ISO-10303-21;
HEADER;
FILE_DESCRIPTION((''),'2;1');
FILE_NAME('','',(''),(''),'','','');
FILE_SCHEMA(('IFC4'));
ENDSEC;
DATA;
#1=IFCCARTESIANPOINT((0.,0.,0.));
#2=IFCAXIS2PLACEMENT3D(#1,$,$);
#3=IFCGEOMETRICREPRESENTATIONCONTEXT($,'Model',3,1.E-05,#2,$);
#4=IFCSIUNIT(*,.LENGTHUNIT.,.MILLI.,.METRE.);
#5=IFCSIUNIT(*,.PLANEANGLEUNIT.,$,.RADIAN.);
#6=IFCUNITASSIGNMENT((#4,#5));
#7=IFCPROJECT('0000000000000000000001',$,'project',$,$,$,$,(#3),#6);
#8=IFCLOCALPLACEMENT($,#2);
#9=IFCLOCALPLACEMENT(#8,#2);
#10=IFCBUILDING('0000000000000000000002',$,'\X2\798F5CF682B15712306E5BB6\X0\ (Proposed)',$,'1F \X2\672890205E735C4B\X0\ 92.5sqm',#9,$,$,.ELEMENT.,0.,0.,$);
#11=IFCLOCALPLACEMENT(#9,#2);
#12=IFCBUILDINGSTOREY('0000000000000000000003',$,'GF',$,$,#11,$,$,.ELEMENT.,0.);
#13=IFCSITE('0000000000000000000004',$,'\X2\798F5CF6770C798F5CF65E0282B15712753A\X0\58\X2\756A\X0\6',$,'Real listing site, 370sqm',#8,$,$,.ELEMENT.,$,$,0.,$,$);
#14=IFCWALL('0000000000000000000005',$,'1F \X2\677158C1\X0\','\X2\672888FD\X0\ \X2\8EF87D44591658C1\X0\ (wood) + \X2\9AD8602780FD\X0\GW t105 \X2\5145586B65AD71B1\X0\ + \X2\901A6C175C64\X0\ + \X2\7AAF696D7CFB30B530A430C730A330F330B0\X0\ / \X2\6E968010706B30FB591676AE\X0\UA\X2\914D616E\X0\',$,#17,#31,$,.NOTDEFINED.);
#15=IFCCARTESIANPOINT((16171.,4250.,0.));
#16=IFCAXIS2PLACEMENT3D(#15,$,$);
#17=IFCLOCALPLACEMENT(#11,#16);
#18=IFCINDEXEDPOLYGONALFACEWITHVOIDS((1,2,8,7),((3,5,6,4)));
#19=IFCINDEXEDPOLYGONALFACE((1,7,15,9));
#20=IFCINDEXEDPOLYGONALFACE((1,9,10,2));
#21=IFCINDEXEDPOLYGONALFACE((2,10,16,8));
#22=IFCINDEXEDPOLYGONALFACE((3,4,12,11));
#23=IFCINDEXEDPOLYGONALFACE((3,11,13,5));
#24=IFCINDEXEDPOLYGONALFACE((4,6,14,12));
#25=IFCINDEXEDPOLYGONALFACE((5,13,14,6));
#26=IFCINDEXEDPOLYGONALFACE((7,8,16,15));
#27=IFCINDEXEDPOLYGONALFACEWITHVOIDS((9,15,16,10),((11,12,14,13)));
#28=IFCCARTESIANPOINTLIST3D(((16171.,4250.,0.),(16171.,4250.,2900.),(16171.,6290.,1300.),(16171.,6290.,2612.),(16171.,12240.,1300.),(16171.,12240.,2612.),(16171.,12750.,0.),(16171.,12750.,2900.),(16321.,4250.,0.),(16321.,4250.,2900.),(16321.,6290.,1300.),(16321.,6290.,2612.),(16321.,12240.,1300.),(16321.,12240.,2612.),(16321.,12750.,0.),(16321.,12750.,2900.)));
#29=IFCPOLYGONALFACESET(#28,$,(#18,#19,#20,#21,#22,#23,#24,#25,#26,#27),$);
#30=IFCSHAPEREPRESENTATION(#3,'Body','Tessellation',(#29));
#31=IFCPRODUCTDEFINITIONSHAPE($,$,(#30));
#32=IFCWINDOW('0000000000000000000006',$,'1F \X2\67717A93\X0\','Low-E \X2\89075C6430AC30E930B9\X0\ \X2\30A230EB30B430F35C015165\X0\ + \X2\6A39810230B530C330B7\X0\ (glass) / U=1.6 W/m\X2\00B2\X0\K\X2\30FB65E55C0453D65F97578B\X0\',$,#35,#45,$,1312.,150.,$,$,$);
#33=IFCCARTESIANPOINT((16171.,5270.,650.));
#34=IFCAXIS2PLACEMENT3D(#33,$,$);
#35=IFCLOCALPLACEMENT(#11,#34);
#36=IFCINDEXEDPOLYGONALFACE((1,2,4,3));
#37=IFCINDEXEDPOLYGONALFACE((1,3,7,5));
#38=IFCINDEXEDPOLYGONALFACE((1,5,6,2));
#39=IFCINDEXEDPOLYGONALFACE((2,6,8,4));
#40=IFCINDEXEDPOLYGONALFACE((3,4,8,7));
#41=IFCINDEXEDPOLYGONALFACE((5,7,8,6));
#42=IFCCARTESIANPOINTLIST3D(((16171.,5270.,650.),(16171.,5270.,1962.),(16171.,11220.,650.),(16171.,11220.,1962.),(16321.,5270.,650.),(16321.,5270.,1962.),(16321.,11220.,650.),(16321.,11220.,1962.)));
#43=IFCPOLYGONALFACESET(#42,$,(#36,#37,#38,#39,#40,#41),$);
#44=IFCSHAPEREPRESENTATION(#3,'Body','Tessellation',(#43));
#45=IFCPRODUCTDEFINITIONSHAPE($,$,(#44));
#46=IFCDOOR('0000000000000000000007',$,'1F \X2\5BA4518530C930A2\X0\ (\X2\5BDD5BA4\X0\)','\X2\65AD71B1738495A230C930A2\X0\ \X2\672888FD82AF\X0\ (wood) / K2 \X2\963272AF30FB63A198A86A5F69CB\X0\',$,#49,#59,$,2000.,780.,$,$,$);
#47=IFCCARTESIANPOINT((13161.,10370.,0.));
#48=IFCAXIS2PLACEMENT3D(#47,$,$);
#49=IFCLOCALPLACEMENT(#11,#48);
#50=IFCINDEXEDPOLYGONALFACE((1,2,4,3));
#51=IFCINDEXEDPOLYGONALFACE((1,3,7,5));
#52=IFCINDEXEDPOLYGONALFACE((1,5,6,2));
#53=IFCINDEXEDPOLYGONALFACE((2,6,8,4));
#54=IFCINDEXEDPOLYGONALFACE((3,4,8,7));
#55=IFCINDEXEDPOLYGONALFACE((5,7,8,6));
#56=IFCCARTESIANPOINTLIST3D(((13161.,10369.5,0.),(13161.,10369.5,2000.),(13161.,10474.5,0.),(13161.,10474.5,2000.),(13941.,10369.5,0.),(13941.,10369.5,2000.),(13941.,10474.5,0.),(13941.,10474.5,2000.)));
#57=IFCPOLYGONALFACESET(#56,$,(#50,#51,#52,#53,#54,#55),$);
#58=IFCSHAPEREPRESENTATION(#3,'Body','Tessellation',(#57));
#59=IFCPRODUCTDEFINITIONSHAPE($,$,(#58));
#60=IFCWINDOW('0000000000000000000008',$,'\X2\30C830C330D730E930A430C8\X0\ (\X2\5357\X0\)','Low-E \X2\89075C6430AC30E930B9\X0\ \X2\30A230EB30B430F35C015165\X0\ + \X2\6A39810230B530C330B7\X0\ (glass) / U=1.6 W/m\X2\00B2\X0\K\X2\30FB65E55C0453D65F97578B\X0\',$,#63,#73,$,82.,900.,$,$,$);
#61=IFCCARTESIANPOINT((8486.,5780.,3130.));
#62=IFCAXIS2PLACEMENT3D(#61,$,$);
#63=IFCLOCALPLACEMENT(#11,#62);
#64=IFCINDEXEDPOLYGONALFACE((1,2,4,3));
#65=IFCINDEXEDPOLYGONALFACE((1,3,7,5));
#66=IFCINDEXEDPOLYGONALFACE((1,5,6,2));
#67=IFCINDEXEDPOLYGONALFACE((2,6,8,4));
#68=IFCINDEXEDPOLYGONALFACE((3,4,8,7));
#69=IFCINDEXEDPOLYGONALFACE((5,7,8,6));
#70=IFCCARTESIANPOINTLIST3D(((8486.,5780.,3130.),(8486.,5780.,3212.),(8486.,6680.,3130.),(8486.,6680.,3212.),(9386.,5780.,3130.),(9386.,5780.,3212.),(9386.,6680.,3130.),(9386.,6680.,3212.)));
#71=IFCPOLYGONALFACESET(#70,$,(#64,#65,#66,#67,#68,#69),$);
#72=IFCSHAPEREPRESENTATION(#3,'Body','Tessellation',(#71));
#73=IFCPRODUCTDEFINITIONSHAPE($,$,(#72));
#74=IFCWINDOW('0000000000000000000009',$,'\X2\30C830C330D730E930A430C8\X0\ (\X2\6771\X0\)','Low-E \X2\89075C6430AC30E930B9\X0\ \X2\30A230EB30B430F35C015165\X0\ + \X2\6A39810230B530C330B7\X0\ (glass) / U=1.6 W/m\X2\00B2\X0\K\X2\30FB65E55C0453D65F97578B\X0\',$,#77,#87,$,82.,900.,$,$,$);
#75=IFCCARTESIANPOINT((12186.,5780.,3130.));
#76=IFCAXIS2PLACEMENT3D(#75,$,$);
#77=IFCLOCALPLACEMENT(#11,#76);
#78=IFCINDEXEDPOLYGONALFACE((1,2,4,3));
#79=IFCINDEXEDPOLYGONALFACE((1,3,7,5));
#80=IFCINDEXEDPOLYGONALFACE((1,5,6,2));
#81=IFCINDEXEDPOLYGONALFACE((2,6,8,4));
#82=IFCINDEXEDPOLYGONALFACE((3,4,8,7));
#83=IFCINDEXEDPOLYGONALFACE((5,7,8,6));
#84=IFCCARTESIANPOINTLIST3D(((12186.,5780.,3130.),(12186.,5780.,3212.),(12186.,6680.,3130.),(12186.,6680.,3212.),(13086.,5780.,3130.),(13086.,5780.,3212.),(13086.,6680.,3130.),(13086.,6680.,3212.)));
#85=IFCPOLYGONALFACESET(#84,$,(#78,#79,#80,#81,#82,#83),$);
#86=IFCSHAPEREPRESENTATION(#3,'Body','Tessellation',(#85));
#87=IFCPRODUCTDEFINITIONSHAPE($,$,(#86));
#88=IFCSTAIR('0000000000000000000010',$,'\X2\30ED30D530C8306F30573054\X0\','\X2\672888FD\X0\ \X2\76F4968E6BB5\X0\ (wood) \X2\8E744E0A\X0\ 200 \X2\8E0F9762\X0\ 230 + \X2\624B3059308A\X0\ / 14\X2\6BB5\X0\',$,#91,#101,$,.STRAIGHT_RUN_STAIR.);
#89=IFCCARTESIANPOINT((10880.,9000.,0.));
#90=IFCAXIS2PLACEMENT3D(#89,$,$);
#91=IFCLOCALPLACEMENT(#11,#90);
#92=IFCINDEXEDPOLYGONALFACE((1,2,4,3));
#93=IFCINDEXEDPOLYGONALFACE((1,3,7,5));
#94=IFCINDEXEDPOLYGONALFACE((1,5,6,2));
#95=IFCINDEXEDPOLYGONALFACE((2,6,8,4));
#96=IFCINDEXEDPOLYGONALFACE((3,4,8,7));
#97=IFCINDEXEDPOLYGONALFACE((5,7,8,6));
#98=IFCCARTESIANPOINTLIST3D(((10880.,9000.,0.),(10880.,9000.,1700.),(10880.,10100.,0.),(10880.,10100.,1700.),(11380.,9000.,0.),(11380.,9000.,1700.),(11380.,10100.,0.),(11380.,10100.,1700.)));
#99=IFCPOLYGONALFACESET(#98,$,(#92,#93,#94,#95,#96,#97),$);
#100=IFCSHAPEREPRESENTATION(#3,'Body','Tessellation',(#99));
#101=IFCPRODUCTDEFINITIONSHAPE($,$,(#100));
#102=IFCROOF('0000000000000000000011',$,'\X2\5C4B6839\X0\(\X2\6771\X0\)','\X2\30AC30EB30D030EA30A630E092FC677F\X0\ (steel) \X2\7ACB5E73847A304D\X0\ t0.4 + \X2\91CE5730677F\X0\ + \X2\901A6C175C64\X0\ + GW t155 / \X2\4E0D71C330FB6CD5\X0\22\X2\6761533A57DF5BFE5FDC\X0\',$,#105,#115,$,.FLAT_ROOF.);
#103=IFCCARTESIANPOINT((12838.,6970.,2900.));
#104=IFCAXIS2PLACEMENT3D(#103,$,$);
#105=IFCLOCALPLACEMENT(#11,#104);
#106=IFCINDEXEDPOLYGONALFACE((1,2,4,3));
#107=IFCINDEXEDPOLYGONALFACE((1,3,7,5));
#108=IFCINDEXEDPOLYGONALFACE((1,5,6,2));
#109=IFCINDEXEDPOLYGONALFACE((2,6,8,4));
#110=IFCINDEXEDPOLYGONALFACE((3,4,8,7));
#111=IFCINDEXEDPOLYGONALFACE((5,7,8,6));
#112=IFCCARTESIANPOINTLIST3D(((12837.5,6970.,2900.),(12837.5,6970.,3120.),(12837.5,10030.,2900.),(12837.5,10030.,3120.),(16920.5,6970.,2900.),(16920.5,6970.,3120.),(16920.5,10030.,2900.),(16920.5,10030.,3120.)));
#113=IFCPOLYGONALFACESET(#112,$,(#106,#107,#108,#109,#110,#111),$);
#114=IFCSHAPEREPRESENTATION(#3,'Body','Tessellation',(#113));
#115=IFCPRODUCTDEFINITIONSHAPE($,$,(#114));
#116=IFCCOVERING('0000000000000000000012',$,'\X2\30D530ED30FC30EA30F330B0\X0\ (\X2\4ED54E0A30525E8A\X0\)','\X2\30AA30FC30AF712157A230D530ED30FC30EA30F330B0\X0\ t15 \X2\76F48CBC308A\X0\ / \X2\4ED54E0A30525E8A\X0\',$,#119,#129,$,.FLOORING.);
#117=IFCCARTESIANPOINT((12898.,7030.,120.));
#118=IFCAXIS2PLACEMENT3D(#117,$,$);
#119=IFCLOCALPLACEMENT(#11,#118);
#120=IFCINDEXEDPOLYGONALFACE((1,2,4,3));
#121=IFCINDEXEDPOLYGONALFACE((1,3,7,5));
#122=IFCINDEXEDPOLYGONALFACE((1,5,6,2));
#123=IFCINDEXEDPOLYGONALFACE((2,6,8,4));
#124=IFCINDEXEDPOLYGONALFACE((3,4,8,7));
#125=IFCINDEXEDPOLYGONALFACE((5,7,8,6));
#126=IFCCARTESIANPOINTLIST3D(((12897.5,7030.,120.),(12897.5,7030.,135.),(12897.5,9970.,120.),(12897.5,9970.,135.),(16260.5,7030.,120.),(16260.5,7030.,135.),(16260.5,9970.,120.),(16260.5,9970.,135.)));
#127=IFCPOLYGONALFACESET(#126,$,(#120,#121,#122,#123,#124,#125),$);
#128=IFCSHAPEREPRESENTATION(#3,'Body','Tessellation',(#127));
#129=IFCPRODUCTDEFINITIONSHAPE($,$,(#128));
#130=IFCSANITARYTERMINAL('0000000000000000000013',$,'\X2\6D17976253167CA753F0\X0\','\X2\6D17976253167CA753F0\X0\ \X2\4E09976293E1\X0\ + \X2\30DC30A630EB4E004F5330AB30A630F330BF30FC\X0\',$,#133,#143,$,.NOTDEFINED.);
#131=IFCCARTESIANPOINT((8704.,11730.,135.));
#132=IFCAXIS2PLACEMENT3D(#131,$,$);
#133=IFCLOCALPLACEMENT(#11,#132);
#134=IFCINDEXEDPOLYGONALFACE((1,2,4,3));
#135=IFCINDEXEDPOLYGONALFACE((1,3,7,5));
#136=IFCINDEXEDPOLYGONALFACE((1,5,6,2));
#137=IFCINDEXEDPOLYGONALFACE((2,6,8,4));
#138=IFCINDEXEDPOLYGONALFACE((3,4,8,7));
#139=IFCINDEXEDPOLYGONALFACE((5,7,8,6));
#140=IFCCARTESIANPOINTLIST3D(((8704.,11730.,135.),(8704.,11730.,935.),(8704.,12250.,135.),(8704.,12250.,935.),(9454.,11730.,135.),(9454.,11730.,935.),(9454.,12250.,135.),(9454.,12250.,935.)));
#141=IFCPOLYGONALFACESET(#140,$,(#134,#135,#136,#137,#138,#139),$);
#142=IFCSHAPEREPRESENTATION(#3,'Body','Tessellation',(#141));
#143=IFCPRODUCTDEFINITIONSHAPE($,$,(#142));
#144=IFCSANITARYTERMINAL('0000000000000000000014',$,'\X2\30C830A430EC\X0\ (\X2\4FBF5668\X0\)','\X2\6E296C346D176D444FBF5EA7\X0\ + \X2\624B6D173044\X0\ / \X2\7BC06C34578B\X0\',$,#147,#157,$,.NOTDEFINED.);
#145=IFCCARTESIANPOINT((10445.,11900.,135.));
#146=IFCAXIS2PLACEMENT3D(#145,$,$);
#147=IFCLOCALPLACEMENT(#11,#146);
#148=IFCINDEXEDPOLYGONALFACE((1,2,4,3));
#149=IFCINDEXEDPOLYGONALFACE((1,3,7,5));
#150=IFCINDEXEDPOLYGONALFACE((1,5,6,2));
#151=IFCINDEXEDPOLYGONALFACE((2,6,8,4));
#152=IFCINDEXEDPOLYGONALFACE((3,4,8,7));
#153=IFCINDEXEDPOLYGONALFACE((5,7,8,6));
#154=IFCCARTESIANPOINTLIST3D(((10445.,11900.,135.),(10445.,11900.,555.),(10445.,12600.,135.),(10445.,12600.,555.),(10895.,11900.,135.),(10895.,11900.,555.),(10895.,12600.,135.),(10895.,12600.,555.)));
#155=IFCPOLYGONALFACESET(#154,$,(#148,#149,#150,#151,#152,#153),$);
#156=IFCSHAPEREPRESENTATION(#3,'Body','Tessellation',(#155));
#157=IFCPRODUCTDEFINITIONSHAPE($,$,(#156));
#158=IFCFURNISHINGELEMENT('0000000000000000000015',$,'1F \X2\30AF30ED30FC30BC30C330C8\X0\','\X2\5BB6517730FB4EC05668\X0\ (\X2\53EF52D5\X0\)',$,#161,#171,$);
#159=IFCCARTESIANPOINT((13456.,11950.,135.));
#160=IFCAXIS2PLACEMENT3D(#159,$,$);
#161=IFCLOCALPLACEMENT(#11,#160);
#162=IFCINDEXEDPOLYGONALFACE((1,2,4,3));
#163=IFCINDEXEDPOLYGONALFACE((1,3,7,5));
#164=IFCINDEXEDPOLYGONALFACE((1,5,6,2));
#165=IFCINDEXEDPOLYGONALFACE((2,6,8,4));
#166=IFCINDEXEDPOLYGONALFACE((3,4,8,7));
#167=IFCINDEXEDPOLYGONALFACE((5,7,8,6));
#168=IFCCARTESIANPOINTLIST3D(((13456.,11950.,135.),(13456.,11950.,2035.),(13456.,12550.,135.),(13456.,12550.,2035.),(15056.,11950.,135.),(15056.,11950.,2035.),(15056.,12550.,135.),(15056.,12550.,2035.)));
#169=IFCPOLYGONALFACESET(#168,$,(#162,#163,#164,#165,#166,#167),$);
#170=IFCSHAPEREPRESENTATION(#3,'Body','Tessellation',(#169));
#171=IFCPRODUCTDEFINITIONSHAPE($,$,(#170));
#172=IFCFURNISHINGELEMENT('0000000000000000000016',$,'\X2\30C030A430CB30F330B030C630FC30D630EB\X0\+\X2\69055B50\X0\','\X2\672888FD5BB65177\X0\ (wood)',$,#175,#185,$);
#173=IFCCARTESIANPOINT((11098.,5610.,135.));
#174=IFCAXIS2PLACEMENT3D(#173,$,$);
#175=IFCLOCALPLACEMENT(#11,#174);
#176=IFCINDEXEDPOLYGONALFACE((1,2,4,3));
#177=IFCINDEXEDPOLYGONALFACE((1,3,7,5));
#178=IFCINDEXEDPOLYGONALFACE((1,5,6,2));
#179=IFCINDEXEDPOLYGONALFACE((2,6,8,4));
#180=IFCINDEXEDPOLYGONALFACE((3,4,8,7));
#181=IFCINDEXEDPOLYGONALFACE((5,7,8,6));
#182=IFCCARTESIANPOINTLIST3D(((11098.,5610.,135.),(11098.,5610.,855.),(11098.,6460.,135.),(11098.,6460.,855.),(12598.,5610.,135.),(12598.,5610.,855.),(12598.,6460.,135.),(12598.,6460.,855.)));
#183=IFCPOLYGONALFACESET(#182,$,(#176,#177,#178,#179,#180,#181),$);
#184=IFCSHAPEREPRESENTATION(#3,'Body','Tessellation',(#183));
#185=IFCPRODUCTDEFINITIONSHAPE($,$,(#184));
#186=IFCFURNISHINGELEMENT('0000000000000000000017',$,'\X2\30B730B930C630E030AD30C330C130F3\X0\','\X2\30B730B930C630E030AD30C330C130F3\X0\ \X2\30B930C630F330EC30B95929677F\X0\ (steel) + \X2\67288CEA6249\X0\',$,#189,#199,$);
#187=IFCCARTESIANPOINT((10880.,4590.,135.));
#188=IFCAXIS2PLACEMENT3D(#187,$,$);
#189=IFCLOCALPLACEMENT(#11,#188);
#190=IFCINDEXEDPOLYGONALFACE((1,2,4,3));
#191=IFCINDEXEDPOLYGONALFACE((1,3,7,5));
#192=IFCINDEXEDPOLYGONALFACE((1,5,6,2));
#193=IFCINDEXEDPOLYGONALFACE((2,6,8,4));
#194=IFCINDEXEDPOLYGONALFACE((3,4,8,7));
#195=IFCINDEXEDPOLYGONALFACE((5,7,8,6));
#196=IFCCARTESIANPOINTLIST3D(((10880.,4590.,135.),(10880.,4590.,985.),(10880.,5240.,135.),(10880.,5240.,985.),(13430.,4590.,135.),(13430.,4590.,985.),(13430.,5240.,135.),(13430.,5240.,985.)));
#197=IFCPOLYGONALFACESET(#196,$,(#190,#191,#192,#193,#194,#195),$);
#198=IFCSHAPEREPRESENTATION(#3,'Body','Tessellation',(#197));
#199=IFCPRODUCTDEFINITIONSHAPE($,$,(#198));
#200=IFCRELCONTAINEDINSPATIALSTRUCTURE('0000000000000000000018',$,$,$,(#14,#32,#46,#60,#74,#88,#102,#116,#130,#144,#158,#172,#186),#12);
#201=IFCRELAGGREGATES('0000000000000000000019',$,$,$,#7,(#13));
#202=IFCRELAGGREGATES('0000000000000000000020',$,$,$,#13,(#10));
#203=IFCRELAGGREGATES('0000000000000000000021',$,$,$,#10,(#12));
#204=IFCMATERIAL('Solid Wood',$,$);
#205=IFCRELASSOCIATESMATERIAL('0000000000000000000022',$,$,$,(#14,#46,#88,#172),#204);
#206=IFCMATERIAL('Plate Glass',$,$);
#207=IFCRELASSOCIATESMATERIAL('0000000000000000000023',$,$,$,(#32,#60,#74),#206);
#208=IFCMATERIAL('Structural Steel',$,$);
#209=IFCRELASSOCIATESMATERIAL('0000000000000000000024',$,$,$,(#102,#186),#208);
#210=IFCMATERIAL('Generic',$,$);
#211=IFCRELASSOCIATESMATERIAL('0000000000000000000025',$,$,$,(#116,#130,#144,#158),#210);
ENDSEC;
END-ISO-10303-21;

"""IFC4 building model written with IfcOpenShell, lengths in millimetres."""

from ifc_helpers import new_model, si_unit, frame, frame_2d, origin, place, context, project, spatial, rectangle, extrude, material, element, fill, save


model = new_model("IFC4")

# Units and contexts
model_context = context("Model", 3, precision=1e-05, world=origin())
ifc_project = project(units=[si_unit("LENGTHUNIT", "METRE", prefix="MILLI"), si_unit("PLANEANGLEUNIT", "RADIAN")], contexts=[model_context])

# Site, building, storey
site_placement = place(None, origin())
site = spatial("IfcSite", under=ifc_project, at=site_placement, Name="福島県福島市花園町58番6", ObjectType="Real listing site, 370sqm", CompositionType="ELEMENT", RefElevation=0.0)
building_placement = place(site_placement, origin())
building = spatial("IfcBuilding", under=site, at=building_placement, Name="福島花園の家 (Proposed)", ObjectType="1F 木造平屋 92.5sqm", CompositionType="ELEMENT", ElevationOfRefHeight=0.0, ElevationOfTerrain=0.0)
storey_placement = place(building_placement, origin())
storey = spatial("IfcBuildingStorey", under=building, at=storey_placement, Name="GF", CompositionType="ELEMENT", Elevation=0.0)

# Shared definitions
ifc_material_1 = material(Name="Solid Wood")

# Wall, opening, window
wall_1_placement = place(storey_placement, frame((16171.0, 4250.0, 0.0)))
wall_1 = element("IfcWall", 1, at=wall_1_placement, inside=storey, material=ifc_material_1, Name="1F 東壁", Description="木製 軸組外壁 (wood) + 高性能GW t105 充填断熱 + 通気層 + 窯業系サイディング / 準耐火・外皮UA配慮", PredefinedType="NOTDEFINED", context=model_context, shape_type="SweptSolid", body=[
    extrude(rectangle(XDim=150.0, YDim=8500.0, at=frame_2d((75.0, 4250.0))), frame((16171.0, 4250.0, 0.0)), (0.0, 0.0, 1.0), 2900.0),
])
opening_1_placement = place(storey_placement, frame((16171.0, 5270.0, 650.0)))
opening_1 = element("IfcOpeningElement", 2, at=opening_1_placement, cuts=wall_1, PredefinedType="NOTDEFINED", context=model_context, shape_type="SweptSolid", body=[
    extrude(rectangle(XDim=150.0, YDim=5950.0, at=frame_2d((75.0, 2975.0))), frame((16171.0, 5270.0, 650.0)), (0.0, 0.0, 1.0), 1312.0),
])
ifc_material_2 = material(Name="Plate Glass")
window_1_placement = place(storey_placement, frame((16171.0, 5270.0, 650.0)))
window_1 = element("IfcWindow", 3, at=window_1_placement, inside=storey, material=ifc_material_2, Name="1F 東窓", Description="Low-E 複層ガラス アルゴン封入 + 樹脂サッシ (glass) / U=1.6 W/m²K・日射取得型", OverallHeight=1312.0, OverallWidth=150.0, context=model_context, shape_type="SweptSolid", body=[
    extrude(rectangle(XDim=150.0, YDim=5950.0, at=frame_2d((75.0, 2975.0))), frame((16171.0, 5270.0, 650.0)), (0.0, 0.0, 1.0), 1312.0),
])
fill(opening_1, window_1)

# Door
door_placement = place(storey_placement, frame((13161.0, 10370.0, 0.0)))
element("IfcDoor", 4, at=door_placement, inside=storey, material=ifc_material_1, Name="1F 室内ドア (寝室)", Description="断熱玄関ドア 木製芯 (wood) / K2 防犯・採風機構", OverallHeight=2000.0, OverallWidth=780.0, context=model_context, shape_type="SweptSolid", body=[
    extrude(rectangle(XDim=780.0, YDim=105.0, at=frame_2d((390.0, 52.0))), frame((13161.0, 10370.0, 0.0)), (0.0, 0.0, 1.0), 2000.0),
])

# Windows
window_2_placement = place(storey_placement, frame((8486.0, 5780.0, 3130.0)))
element("IfcWindow", 5, at=window_2_placement, inside=storey, material=ifc_material_2, Name="トップライト (南)", Description="Low-E 複層ガラス アルゴン封入 + 樹脂サッシ (glass) / U=1.6 W/m²K・日射取得型", OverallHeight=82.0, OverallWidth=900.0, context=model_context, shape_type="SweptSolid", body=[
    extrude(rectangle(XDim=900.0, YDim=900.0, at=frame_2d((450.0, 450.0))), frame((8486.0, 5780.0, 3130.0)), (0.0, 0.0, 1.0), 82.0),
])
window_3_placement = place(storey_placement, frame((12186.0, 5780.0, 3130.0)))
element("IfcWindow", 6, at=window_3_placement, inside=storey, material=ifc_material_2, Name="トップライト (東)", Description="Low-E 複層ガラス アルゴン封入 + 樹脂サッシ (glass) / U=1.6 W/m²K・日射取得型", OverallHeight=82.0, OverallWidth=900.0, context=model_context, shape_type="SweptSolid", body=[
    extrude(rectangle(XDim=900.0, YDim=900.0, at=frame_2d((450.0, 450.0))), frame((12186.0, 5780.0, 3130.0)), (0.0, 0.0, 1.0), 82.0),
])

# Stair
stair_placement = place(storey_placement, frame((10880.0, 9000.0, 0.0)))
element("IfcStair", 7, at=stair_placement, inside=storey, material=ifc_material_1, Name="ロフトはしご", Description="木製 直階段 (wood) 蹴上 200 踏面 230 + 手すり / 14段", PredefinedType="STRAIGHT_RUN_STAIR", context=model_context, shape_type="SweptSolid", body=[
    extrude(rectangle(XDim=500.0, YDim=1100.0, at=frame_2d((250.0, 550.0))), frame((10880.0, 9000.0, 0.0)), (0.0, 0.0, 1.0), 1700.0),
])

# Roof
ifc_material_3 = material(Name="Structural Steel")
roof_placement = place(storey_placement, frame((12838.0, 6970.0, 2900.0)))
element("IfcRoof", 8, at=roof_placement, inside=storey, material=ifc_material_3, Name="屋根(東)", Description="ガルバリウム鋼板 (steel) 立平葺き t0.4 + 野地板 + 通気層 + GW t155 / 不燃・法22条区域対応", PredefinedType="FLAT_ROOF", context=model_context, shape_type="SweptSolid", body=[
    extrude(rectangle(XDim=4083.0, YDim=3060.0, at=frame_2d((2041.0, 1530.0))), frame((12838.0, 6970.0, 2900.0)), (0.0, 0.0, 1.0), 220.0),
])

# Covering
ifc_material_4 = material(Name="Generic")
covering_placement = place(storey_placement, frame((12898.0, 7030.0, 120.0)))
element("IfcCovering", 9, at=covering_placement, inside=storey, material=ifc_material_4, Name="フローリング (仕上げ床)", Description="オーク無垢フローリング t15 直貼り / 仕上げ床", PredefinedType="FLOORING", context=model_context, shape_type="SweptSolid", body=[
    extrude(rectangle(XDim=3363.0, YDim=2940.0, at=frame_2d((1681.0, 1470.0))), frame((12898.0, 7030.0, 120.0)), (0.0, 0.0, 1.0), 15.0),
])

# Sanitary terminals
sanitary_terminal_1_placement = place(storey_placement, frame((8704.0, 11730.0, 135.0)))
element("IfcSanitaryTerminal", 10, at=sanitary_terminal_1_placement, inside=storey, material=ifc_material_4, Name="洗面化粧台", Description="洗面化粧台 三面鏡 + ボウル一体カウンター", PredefinedType="NOTDEFINED", context=model_context, shape_type="SweptSolid", body=[
    extrude(rectangle(XDim=750.0, YDim=520.0, at=frame_2d((375.0, 260.0))), frame((8704.0, 11730.0, 135.0)), (0.0, 0.0, 1.0), 800.0),
])
sanitary_terminal_2_placement = place(storey_placement, frame((10445.0, 11900.0, 135.0)))
element("IfcSanitaryTerminal", 11, at=sanitary_terminal_2_placement, inside=storey, material=ifc_material_4, Name="トイレ (便器)", Description="温水洗浄便座 + 手洗い / 節水型", PredefinedType="NOTDEFINED", context=model_context, shape_type="SweptSolid", body=[
    extrude(rectangle(XDim=450.0, YDim=700.0, at=frame_2d((225.0, 350.0))), frame((10445.0, 11900.0, 135.0)), (0.0, 0.0, 1.0), 420.0),
])

# Furnishing elements
furnishing_1_placement = place(storey_placement, frame((13456.0, 11950.0, 135.0)))
element("IfcFurnishingElement", 12, at=furnishing_1_placement, inside=storey, material=ifc_material_4, Name="1F クローゼット", Description="家具・什器 (可動)", context=model_context, shape_type="SweptSolid", body=[
    extrude(rectangle(XDim=1600.0, YDim=600.0, at=frame_2d((800.0, 300.0))), frame((13456.0, 11950.0, 135.0)), (0.0, 0.0, 1.0), 1900.0),
])
furnishing_2_placement = place(storey_placement, frame((11098.0, 5610.0, 135.0)))
element("IfcFurnishingElement", 13, at=furnishing_2_placement, inside=storey, material=ifc_material_1, Name="ダイニングテーブル+椅子", Description="木製家具 (wood)", context=model_context, shape_type="SweptSolid", body=[
    extrude(rectangle(XDim=1500.0, YDim=850.0, at=frame_2d((750.0, 425.0))), frame((11098.0, 5610.0, 135.0)), (0.0, 0.0, 1.0), 720.0),
])
furnishing_3_placement = place(storey_placement, frame((10880.0, 4590.0, 135.0)))
element("IfcFurnishingElement", 14, at=furnishing_3_placement, inside=storey, material=ifc_material_3, Name="システムキッチン", Description="システムキッチン ステンレス天板 (steel) + 木質扉", context=model_context, shape_type="SweptSolid", body=[
    extrude(rectangle(XDim=2550.0, YDim=650.0, at=frame_2d((1275.0, 325.0))), frame((10880.0, 4590.0, 135.0)), (0.0, 0.0, 1.0), 850.0),
])

save(model, "model.ifc")
